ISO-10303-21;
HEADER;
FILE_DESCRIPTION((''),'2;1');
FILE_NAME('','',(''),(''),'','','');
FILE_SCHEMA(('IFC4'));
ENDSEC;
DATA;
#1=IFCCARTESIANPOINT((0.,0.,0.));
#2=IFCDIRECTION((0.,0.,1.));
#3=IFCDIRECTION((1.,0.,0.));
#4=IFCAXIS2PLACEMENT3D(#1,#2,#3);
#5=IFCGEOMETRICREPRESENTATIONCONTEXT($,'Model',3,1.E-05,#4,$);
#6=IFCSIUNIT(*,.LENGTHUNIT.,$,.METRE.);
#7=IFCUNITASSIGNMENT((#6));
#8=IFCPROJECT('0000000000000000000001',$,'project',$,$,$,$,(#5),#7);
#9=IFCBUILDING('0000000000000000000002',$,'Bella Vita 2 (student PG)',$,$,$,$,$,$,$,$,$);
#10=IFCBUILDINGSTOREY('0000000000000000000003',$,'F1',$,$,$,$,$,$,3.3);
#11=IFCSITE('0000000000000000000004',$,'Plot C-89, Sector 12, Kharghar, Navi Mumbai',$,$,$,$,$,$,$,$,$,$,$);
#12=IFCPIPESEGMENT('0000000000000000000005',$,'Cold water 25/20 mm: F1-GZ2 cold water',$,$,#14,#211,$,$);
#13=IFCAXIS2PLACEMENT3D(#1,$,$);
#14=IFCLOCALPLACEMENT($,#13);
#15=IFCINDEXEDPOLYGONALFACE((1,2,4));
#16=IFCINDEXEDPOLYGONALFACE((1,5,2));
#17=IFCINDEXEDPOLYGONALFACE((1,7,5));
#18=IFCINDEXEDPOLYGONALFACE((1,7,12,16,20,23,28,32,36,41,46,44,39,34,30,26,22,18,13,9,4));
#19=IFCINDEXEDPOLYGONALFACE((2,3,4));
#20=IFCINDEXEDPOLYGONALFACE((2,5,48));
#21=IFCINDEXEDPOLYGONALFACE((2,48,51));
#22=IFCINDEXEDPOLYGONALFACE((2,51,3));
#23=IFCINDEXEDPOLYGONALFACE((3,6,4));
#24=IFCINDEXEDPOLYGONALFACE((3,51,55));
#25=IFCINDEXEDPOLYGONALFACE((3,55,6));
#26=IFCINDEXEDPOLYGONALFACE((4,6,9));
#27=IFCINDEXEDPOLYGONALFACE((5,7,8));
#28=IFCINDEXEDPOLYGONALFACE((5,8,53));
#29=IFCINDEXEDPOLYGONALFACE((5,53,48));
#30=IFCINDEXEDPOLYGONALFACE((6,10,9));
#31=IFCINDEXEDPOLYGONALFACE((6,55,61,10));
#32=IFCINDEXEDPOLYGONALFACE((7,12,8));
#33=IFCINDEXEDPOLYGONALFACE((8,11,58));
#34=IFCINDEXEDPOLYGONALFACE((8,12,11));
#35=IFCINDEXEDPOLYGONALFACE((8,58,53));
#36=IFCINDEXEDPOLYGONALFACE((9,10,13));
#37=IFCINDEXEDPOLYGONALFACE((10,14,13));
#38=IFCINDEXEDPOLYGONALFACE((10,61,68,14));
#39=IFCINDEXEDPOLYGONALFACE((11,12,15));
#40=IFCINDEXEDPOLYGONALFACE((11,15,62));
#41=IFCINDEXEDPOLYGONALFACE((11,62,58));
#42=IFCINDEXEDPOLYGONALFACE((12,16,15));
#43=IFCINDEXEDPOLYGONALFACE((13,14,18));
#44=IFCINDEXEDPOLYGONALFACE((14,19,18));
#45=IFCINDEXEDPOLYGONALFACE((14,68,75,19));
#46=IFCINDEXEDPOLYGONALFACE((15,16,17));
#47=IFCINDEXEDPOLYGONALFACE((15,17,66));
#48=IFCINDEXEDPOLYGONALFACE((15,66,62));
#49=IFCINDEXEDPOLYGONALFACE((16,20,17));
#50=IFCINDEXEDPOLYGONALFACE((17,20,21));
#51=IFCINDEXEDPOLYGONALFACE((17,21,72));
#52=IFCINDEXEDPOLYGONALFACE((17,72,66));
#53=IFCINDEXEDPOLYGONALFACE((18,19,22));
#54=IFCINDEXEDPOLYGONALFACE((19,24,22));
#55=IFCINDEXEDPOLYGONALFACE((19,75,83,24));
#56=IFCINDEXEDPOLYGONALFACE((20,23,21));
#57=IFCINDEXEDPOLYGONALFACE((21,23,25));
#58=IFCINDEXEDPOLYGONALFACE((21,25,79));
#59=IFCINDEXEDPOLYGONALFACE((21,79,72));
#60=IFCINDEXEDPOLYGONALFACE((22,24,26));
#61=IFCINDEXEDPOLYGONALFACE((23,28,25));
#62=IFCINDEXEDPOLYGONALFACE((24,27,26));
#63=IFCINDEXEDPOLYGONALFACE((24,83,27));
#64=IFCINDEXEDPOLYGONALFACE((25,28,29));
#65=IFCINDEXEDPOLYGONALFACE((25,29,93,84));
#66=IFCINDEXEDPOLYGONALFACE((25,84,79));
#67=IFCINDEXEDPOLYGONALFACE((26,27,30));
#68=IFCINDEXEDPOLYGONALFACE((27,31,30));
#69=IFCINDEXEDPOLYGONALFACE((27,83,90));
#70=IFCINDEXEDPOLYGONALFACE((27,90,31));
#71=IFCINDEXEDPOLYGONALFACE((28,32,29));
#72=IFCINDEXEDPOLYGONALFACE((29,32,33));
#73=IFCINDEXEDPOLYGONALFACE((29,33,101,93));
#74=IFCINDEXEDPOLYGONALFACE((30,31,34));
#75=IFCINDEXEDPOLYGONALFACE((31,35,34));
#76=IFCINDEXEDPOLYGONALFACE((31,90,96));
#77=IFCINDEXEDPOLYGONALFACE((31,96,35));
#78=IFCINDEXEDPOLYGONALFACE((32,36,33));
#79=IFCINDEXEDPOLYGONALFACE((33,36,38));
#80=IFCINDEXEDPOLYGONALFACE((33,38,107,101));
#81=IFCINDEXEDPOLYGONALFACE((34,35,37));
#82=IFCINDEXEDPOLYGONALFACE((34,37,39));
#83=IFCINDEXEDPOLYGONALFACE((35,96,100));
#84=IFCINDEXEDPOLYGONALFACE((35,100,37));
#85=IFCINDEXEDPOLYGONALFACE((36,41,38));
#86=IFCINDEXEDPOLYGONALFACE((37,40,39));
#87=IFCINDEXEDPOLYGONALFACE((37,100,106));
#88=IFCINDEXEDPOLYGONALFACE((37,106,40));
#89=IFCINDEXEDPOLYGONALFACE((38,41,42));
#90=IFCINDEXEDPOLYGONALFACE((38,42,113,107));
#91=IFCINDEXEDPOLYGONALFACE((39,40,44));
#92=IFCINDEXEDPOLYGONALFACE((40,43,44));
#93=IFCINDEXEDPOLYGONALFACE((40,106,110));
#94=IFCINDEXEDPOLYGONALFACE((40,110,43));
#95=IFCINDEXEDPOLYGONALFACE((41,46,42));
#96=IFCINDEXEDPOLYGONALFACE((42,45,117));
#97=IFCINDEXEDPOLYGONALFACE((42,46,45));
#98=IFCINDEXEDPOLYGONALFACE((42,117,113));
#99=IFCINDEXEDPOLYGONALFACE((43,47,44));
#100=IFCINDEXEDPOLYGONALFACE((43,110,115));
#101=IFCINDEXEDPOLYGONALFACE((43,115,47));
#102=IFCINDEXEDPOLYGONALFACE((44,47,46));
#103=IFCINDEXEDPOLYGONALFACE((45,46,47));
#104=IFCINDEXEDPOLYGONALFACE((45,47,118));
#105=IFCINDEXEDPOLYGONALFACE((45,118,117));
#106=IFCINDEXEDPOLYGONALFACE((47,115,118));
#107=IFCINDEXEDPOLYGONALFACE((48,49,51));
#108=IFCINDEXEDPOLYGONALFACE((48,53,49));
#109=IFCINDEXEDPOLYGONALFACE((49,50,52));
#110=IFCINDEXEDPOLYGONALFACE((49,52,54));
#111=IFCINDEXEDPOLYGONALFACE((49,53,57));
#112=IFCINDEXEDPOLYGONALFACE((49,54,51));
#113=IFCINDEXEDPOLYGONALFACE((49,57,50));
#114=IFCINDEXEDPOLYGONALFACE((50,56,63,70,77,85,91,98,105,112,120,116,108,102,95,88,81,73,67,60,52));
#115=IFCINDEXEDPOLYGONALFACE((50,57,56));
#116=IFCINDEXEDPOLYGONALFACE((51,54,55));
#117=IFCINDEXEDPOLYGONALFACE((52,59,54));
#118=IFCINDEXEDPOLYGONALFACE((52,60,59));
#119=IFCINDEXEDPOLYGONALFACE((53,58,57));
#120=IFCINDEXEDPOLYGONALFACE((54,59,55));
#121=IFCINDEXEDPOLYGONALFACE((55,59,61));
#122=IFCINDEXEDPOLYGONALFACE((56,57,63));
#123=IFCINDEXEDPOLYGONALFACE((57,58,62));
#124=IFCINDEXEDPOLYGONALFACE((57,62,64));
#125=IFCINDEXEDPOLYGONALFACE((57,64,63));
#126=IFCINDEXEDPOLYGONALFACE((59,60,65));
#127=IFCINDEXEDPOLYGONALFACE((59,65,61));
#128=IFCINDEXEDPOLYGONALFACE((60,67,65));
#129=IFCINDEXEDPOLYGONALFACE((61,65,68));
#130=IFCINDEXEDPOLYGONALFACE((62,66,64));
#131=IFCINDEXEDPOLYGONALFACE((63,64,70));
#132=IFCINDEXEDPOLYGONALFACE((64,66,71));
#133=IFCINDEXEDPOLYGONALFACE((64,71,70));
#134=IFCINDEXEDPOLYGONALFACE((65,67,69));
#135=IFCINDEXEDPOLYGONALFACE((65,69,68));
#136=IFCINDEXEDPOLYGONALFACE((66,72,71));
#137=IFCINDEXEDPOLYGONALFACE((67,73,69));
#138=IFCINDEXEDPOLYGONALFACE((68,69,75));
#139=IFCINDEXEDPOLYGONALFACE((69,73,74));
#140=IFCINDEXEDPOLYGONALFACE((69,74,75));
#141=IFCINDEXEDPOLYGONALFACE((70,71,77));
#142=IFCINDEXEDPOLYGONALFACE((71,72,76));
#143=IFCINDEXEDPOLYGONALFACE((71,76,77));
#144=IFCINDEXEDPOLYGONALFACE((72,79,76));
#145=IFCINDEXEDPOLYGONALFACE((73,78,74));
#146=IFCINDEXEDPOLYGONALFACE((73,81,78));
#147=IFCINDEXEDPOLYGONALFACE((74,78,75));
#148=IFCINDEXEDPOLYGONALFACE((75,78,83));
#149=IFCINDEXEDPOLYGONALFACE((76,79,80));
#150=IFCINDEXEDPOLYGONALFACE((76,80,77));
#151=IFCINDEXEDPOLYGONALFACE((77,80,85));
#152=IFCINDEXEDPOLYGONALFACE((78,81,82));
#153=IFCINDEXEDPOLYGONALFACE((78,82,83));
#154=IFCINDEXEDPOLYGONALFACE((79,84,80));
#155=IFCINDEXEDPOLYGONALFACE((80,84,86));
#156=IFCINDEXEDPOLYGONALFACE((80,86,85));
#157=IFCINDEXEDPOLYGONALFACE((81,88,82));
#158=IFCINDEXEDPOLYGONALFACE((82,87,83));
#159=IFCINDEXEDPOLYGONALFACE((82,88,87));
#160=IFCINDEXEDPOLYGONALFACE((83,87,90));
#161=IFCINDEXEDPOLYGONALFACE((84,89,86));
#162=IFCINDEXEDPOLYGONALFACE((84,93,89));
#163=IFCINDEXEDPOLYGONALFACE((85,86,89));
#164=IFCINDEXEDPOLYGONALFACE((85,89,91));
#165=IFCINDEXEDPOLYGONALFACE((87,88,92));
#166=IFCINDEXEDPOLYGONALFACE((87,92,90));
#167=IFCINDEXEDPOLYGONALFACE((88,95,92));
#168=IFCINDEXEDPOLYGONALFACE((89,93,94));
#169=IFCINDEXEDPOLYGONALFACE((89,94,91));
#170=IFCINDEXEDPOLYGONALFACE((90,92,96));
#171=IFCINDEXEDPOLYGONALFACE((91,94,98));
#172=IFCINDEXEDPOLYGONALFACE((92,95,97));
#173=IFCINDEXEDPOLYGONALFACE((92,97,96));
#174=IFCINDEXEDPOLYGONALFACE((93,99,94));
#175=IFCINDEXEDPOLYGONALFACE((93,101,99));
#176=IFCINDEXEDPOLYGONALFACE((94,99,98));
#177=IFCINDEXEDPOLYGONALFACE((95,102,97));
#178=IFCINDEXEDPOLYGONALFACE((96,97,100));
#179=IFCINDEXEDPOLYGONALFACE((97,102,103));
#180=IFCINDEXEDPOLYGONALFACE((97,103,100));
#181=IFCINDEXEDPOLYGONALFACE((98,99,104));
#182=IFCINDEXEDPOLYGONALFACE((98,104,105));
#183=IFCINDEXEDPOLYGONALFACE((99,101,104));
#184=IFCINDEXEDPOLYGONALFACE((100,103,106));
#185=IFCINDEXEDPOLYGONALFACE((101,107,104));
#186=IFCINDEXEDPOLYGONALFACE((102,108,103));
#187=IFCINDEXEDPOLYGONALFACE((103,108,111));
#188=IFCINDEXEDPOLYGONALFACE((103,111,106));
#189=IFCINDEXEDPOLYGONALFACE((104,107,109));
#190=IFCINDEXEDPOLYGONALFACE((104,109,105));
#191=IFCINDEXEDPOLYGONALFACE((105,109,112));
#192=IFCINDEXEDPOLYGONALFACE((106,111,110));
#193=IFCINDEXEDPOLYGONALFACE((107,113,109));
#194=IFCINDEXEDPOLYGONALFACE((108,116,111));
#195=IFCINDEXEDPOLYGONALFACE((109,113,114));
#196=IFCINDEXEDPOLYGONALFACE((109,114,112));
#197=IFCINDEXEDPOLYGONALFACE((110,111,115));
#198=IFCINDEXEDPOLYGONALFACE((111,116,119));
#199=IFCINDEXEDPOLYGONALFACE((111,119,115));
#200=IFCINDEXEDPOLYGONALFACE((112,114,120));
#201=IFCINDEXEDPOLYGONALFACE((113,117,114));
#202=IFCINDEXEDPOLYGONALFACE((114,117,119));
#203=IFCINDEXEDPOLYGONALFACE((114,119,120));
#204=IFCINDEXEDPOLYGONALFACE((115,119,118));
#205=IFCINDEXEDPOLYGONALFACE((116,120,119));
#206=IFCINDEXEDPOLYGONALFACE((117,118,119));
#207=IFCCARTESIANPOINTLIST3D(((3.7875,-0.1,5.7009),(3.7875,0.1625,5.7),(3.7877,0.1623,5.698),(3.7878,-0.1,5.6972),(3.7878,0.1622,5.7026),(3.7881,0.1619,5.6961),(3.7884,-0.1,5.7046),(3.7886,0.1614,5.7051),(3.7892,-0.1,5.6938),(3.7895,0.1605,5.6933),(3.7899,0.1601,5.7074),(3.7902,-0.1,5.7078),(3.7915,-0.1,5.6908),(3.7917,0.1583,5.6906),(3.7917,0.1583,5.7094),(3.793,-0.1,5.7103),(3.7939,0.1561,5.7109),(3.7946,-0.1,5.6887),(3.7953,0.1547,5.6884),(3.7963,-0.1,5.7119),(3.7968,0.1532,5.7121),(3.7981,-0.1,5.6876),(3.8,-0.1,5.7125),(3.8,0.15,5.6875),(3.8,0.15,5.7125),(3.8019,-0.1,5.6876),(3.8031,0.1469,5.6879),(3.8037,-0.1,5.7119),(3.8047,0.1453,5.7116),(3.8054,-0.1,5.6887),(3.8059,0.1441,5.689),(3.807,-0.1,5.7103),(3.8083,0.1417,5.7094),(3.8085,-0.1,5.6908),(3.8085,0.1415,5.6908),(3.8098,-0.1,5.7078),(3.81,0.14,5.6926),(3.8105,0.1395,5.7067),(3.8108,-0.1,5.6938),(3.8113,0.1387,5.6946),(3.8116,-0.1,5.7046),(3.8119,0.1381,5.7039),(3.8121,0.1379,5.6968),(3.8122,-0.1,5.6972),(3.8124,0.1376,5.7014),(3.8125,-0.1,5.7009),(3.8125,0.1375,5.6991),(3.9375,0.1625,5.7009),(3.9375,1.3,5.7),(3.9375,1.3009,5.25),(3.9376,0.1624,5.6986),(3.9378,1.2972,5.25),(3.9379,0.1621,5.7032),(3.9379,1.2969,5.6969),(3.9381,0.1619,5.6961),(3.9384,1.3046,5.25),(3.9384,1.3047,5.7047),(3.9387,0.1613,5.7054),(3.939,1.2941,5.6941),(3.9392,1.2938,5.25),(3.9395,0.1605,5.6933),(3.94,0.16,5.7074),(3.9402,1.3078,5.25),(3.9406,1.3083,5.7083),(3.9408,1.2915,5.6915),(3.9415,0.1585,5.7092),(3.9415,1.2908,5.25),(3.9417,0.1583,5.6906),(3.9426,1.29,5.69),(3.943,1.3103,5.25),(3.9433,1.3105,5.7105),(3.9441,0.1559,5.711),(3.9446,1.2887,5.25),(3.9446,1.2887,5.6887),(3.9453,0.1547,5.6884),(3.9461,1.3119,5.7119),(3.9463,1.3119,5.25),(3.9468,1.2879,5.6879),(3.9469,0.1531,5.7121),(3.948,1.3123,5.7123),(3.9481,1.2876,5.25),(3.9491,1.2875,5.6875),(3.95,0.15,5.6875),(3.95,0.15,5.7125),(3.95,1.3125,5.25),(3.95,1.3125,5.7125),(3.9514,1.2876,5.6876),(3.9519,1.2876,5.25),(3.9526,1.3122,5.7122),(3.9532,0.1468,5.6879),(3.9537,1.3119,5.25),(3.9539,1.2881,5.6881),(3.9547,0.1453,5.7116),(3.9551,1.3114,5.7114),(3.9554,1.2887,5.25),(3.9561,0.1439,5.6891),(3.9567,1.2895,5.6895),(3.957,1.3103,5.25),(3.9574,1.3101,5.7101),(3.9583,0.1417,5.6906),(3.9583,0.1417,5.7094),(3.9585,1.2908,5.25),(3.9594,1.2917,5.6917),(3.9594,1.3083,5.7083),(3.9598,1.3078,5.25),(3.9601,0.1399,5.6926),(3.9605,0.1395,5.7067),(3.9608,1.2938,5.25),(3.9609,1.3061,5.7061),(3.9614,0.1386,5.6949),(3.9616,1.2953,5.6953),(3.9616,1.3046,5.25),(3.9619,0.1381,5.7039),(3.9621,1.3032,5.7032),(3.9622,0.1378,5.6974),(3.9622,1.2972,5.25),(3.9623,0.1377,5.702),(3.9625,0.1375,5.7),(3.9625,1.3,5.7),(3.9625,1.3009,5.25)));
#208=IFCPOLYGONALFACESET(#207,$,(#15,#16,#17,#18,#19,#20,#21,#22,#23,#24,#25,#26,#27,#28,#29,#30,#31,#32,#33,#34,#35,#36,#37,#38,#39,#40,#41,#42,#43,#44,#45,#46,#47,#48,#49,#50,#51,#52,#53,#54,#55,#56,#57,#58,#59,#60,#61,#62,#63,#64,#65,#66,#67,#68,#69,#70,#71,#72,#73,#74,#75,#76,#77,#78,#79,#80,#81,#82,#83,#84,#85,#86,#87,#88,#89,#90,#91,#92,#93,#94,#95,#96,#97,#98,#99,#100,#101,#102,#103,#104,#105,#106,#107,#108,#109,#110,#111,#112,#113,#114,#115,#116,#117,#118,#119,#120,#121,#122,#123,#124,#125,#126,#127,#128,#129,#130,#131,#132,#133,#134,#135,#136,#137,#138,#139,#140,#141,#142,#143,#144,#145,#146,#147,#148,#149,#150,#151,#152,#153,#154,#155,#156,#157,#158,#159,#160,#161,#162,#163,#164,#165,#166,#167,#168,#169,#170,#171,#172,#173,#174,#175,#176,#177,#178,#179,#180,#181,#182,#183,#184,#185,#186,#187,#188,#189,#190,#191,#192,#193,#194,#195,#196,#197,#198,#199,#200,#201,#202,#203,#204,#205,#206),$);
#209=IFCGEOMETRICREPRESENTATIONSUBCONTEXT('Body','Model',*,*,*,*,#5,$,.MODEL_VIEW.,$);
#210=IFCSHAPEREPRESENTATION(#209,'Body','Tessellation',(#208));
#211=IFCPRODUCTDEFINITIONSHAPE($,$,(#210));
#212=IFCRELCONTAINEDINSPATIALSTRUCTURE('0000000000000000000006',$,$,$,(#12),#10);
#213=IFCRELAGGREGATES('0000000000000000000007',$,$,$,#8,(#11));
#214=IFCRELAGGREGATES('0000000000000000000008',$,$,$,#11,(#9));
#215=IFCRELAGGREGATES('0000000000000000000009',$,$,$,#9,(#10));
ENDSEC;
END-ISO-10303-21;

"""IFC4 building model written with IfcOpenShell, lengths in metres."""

from ifc_helpers import new_model, entity, si_unit, origin, origin_with_axes, place, context, subcontext, project, spatial, element, save


model = new_model("IFC4")

# Units and contexts
model_context = context("Model", 3, precision=1e-05, world=origin_with_axes())
body_context = subcontext(model_context, "Body", "Model", "MODEL_VIEW")
ifc_project = project(units=[si_unit("LENGTHUNIT", "METRE")], contexts=[model_context])

# Site, building, storey
site = spatial("IfcSite", under=ifc_project, Name="Plot C-89, Sector 12, Kharghar, Navi Mumbai")
building = spatial("IfcBuilding", under=site, Name="Bella Vita 2 (student PG)")
storey = spatial("IfcBuildingStorey", under=building, Name="F1", Elevation=3.3)

# Pipe segment
pipe_segment_1_placement = place(None, origin())
element("IfcPipeSegment", 1, at=pipe_segment_1_placement, inside=storey, Name="Cold water 25/20 mm: F1-GZ2 cold water", context=body_context, shape_type="AdvancedSweptSolid", body=[
    entity("IfcSweptDiskSolid", entity("IfcPolyline", [entity("IfcCartesianPoint", [3.8, -0.1, 5.7]), entity("IfcCartesianPoint", [3.8, 0.15, 5.7]), entity("IfcCartesianPoint", [3.95, 0.15, 5.7]), entity("IfcCartesianPoint", [3.95, 1.3, 5.7]), entity("IfcCartesianPoint", [3.95, 1.3, 5.25])]), 0.0125),
])

save(model, "model.ifc")
